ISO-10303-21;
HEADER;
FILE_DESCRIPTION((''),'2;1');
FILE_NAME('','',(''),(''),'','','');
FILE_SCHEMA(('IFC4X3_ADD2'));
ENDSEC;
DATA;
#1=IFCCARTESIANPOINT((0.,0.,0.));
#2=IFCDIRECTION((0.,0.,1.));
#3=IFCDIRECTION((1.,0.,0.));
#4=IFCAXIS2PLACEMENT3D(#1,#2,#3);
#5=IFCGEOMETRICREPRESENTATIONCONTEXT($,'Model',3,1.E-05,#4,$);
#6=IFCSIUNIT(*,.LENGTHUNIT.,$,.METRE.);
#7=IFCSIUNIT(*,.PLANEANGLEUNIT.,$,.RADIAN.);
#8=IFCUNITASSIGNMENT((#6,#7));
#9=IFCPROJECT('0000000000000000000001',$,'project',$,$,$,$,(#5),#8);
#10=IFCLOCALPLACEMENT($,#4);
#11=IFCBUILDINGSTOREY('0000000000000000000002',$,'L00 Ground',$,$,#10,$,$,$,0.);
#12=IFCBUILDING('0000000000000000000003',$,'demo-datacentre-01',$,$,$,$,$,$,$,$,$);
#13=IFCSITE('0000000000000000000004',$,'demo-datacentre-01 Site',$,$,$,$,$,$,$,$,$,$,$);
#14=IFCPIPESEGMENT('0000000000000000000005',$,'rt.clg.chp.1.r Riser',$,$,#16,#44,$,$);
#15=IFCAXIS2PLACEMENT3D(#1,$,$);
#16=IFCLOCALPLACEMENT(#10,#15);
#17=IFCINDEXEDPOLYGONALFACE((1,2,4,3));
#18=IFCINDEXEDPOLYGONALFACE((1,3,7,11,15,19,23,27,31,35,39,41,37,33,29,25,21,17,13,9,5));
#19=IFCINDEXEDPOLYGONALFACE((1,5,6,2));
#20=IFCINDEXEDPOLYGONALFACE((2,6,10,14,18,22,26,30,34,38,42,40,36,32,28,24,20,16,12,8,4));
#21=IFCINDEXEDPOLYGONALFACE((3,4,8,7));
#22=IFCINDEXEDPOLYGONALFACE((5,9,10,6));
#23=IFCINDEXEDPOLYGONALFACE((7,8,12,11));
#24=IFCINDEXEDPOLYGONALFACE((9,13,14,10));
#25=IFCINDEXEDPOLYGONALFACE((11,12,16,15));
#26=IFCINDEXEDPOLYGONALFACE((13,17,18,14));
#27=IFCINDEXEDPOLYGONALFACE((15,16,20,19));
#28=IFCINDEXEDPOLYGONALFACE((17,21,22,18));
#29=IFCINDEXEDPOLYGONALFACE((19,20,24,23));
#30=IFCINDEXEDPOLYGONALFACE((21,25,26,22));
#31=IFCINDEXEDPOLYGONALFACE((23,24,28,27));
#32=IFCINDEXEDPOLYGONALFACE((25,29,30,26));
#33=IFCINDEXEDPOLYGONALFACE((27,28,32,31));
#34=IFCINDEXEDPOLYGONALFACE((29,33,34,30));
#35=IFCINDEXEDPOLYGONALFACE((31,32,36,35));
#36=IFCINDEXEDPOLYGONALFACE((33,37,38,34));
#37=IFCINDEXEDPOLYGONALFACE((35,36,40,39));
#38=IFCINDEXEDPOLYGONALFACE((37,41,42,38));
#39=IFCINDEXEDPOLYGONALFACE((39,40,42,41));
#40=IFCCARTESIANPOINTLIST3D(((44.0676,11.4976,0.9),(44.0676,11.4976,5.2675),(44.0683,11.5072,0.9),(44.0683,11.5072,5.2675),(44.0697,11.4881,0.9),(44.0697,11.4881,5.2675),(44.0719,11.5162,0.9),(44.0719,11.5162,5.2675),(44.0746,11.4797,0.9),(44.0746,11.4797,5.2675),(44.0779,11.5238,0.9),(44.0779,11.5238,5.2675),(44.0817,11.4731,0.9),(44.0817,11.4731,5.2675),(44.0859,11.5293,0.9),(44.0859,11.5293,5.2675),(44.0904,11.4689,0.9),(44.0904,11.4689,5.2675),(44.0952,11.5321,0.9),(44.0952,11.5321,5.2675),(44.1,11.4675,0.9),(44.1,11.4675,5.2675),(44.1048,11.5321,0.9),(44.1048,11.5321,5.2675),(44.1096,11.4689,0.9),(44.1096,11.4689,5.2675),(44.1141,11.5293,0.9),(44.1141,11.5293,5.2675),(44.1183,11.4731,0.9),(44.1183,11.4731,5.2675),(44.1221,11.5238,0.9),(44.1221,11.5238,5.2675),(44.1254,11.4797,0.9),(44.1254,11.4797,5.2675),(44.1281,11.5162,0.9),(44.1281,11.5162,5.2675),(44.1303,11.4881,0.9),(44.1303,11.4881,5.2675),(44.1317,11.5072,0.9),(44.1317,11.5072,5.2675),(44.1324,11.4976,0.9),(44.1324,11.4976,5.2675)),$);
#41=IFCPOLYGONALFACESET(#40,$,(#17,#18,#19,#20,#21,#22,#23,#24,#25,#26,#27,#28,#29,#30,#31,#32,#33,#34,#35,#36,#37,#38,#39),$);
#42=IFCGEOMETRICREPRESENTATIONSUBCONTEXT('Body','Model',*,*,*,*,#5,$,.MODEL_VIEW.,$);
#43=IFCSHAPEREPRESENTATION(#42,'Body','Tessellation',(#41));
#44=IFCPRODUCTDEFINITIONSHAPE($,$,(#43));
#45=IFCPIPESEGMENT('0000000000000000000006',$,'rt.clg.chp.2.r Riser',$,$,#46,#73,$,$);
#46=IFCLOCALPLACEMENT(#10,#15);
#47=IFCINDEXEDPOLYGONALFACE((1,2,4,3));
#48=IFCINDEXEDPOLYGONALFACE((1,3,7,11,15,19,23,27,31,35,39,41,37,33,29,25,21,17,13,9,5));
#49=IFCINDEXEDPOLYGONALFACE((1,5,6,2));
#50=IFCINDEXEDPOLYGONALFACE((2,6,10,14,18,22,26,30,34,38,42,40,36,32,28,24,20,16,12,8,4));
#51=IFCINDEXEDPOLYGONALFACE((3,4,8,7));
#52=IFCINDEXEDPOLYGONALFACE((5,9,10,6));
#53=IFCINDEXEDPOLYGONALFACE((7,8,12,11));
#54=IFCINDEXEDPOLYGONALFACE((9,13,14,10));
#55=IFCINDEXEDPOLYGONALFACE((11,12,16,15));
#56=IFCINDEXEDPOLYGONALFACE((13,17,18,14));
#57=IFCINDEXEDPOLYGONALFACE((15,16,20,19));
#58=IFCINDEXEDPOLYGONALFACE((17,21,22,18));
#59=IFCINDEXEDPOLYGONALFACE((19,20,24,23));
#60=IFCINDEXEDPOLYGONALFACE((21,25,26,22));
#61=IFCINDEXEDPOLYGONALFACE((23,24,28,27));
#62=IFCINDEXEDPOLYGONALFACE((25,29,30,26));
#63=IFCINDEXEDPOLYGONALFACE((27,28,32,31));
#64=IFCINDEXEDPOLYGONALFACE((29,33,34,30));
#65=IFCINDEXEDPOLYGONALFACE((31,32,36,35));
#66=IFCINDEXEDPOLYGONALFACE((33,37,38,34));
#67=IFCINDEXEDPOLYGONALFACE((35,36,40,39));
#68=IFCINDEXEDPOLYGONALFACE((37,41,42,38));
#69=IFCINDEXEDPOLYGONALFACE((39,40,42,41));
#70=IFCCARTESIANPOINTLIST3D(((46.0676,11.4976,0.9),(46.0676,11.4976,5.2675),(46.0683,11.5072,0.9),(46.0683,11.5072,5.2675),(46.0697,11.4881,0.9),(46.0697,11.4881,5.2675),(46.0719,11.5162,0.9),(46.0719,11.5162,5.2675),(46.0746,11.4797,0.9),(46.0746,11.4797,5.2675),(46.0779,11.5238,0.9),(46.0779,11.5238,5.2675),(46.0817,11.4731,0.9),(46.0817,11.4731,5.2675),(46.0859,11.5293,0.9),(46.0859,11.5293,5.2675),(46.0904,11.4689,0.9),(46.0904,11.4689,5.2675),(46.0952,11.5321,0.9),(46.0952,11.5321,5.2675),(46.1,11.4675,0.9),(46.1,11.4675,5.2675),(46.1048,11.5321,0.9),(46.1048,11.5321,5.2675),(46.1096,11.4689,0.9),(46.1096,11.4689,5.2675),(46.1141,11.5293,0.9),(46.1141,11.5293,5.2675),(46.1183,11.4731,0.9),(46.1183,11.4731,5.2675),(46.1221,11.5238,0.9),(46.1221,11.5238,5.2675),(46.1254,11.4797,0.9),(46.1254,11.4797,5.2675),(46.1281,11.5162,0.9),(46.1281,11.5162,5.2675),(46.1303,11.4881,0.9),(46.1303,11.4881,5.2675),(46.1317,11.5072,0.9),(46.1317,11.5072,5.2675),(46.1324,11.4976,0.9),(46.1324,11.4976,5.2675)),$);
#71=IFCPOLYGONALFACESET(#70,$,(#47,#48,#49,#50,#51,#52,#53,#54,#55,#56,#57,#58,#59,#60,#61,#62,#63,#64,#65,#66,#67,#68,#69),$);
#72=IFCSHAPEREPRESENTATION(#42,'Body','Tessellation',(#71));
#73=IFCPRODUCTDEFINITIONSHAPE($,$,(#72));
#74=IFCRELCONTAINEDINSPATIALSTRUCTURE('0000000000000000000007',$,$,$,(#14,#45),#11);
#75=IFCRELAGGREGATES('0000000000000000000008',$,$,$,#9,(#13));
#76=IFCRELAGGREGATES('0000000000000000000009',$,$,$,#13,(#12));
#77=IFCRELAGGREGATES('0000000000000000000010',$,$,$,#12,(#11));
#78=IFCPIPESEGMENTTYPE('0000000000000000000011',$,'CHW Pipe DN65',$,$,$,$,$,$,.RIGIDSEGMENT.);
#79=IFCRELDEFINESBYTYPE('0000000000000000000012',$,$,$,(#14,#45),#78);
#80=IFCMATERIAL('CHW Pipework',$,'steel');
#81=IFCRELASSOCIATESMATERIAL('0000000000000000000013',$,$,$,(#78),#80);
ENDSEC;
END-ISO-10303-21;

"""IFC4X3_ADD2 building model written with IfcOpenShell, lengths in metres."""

from ifc_helpers import new_model, si_unit, frame, origin_with_axes, place, context, subcontext, project, spatial, circle, extrude, material, type_object, element, save


model = new_model("IFC4X3_ADD2")

# Units and contexts
model_context = context("Model", 3, precision=1e-05, world=origin_with_axes())
body_context = subcontext(model_context, "Body", "Model", "MODEL_VIEW")
ifc_project = project(units=[si_unit("LENGTHUNIT", "METRE"), si_unit("PLANEANGLEUNIT", "RADIAN")], contexts=[model_context])

# Site, building, storey
site = spatial("IfcSite", under=ifc_project, Name="demo-datacentre-01 Site")
building = spatial("IfcBuilding", under=site, Name="demo-datacentre-01")
storey_placement = place(None, origin_with_axes())
storey = spatial("IfcBuildingStorey", under=building, at=storey_placement, Name="L00 Ground", Elevation=0.0)

# Shared definitions
ifc_material = material(Name="CHW Pipework", Category="steel")

# Pipe segments
pipe_segment_type_1 = type_object("IfcPipeSegmentType", Name="CHW Pipe DN65", PredefinedType="RIGIDSEGMENT", material=ifc_material)
for number, where, z_axis, x_axis, name in (
    (1, (44.1, 11.5, 0.9), (0.0, 0.0, 1.0), (0.0, -1.0, 0.0), "rt.clg.chp.1.r Riser"),
    (2, (46.1, 11.5, 0.9), (0.0, 0.0, 1.0), (0.0, -1.0, 0.0), "rt.clg.chp.2.r Riser"),
):
    element("IfcPipeSegment", number, at=place(storey_placement, frame(where, z_axis=z_axis, x_axis=x_axis)), inside=storey, type_object=pipe_segment_type_1, Name=name, context=body_context, shape_type="SweptSolid", body=[
        extrude(circle(Radius=0.0325), origin_with_axes(), (0.0, 0.0, 1.0), 4.3675),
    ])

save(model, "model.ifc")
